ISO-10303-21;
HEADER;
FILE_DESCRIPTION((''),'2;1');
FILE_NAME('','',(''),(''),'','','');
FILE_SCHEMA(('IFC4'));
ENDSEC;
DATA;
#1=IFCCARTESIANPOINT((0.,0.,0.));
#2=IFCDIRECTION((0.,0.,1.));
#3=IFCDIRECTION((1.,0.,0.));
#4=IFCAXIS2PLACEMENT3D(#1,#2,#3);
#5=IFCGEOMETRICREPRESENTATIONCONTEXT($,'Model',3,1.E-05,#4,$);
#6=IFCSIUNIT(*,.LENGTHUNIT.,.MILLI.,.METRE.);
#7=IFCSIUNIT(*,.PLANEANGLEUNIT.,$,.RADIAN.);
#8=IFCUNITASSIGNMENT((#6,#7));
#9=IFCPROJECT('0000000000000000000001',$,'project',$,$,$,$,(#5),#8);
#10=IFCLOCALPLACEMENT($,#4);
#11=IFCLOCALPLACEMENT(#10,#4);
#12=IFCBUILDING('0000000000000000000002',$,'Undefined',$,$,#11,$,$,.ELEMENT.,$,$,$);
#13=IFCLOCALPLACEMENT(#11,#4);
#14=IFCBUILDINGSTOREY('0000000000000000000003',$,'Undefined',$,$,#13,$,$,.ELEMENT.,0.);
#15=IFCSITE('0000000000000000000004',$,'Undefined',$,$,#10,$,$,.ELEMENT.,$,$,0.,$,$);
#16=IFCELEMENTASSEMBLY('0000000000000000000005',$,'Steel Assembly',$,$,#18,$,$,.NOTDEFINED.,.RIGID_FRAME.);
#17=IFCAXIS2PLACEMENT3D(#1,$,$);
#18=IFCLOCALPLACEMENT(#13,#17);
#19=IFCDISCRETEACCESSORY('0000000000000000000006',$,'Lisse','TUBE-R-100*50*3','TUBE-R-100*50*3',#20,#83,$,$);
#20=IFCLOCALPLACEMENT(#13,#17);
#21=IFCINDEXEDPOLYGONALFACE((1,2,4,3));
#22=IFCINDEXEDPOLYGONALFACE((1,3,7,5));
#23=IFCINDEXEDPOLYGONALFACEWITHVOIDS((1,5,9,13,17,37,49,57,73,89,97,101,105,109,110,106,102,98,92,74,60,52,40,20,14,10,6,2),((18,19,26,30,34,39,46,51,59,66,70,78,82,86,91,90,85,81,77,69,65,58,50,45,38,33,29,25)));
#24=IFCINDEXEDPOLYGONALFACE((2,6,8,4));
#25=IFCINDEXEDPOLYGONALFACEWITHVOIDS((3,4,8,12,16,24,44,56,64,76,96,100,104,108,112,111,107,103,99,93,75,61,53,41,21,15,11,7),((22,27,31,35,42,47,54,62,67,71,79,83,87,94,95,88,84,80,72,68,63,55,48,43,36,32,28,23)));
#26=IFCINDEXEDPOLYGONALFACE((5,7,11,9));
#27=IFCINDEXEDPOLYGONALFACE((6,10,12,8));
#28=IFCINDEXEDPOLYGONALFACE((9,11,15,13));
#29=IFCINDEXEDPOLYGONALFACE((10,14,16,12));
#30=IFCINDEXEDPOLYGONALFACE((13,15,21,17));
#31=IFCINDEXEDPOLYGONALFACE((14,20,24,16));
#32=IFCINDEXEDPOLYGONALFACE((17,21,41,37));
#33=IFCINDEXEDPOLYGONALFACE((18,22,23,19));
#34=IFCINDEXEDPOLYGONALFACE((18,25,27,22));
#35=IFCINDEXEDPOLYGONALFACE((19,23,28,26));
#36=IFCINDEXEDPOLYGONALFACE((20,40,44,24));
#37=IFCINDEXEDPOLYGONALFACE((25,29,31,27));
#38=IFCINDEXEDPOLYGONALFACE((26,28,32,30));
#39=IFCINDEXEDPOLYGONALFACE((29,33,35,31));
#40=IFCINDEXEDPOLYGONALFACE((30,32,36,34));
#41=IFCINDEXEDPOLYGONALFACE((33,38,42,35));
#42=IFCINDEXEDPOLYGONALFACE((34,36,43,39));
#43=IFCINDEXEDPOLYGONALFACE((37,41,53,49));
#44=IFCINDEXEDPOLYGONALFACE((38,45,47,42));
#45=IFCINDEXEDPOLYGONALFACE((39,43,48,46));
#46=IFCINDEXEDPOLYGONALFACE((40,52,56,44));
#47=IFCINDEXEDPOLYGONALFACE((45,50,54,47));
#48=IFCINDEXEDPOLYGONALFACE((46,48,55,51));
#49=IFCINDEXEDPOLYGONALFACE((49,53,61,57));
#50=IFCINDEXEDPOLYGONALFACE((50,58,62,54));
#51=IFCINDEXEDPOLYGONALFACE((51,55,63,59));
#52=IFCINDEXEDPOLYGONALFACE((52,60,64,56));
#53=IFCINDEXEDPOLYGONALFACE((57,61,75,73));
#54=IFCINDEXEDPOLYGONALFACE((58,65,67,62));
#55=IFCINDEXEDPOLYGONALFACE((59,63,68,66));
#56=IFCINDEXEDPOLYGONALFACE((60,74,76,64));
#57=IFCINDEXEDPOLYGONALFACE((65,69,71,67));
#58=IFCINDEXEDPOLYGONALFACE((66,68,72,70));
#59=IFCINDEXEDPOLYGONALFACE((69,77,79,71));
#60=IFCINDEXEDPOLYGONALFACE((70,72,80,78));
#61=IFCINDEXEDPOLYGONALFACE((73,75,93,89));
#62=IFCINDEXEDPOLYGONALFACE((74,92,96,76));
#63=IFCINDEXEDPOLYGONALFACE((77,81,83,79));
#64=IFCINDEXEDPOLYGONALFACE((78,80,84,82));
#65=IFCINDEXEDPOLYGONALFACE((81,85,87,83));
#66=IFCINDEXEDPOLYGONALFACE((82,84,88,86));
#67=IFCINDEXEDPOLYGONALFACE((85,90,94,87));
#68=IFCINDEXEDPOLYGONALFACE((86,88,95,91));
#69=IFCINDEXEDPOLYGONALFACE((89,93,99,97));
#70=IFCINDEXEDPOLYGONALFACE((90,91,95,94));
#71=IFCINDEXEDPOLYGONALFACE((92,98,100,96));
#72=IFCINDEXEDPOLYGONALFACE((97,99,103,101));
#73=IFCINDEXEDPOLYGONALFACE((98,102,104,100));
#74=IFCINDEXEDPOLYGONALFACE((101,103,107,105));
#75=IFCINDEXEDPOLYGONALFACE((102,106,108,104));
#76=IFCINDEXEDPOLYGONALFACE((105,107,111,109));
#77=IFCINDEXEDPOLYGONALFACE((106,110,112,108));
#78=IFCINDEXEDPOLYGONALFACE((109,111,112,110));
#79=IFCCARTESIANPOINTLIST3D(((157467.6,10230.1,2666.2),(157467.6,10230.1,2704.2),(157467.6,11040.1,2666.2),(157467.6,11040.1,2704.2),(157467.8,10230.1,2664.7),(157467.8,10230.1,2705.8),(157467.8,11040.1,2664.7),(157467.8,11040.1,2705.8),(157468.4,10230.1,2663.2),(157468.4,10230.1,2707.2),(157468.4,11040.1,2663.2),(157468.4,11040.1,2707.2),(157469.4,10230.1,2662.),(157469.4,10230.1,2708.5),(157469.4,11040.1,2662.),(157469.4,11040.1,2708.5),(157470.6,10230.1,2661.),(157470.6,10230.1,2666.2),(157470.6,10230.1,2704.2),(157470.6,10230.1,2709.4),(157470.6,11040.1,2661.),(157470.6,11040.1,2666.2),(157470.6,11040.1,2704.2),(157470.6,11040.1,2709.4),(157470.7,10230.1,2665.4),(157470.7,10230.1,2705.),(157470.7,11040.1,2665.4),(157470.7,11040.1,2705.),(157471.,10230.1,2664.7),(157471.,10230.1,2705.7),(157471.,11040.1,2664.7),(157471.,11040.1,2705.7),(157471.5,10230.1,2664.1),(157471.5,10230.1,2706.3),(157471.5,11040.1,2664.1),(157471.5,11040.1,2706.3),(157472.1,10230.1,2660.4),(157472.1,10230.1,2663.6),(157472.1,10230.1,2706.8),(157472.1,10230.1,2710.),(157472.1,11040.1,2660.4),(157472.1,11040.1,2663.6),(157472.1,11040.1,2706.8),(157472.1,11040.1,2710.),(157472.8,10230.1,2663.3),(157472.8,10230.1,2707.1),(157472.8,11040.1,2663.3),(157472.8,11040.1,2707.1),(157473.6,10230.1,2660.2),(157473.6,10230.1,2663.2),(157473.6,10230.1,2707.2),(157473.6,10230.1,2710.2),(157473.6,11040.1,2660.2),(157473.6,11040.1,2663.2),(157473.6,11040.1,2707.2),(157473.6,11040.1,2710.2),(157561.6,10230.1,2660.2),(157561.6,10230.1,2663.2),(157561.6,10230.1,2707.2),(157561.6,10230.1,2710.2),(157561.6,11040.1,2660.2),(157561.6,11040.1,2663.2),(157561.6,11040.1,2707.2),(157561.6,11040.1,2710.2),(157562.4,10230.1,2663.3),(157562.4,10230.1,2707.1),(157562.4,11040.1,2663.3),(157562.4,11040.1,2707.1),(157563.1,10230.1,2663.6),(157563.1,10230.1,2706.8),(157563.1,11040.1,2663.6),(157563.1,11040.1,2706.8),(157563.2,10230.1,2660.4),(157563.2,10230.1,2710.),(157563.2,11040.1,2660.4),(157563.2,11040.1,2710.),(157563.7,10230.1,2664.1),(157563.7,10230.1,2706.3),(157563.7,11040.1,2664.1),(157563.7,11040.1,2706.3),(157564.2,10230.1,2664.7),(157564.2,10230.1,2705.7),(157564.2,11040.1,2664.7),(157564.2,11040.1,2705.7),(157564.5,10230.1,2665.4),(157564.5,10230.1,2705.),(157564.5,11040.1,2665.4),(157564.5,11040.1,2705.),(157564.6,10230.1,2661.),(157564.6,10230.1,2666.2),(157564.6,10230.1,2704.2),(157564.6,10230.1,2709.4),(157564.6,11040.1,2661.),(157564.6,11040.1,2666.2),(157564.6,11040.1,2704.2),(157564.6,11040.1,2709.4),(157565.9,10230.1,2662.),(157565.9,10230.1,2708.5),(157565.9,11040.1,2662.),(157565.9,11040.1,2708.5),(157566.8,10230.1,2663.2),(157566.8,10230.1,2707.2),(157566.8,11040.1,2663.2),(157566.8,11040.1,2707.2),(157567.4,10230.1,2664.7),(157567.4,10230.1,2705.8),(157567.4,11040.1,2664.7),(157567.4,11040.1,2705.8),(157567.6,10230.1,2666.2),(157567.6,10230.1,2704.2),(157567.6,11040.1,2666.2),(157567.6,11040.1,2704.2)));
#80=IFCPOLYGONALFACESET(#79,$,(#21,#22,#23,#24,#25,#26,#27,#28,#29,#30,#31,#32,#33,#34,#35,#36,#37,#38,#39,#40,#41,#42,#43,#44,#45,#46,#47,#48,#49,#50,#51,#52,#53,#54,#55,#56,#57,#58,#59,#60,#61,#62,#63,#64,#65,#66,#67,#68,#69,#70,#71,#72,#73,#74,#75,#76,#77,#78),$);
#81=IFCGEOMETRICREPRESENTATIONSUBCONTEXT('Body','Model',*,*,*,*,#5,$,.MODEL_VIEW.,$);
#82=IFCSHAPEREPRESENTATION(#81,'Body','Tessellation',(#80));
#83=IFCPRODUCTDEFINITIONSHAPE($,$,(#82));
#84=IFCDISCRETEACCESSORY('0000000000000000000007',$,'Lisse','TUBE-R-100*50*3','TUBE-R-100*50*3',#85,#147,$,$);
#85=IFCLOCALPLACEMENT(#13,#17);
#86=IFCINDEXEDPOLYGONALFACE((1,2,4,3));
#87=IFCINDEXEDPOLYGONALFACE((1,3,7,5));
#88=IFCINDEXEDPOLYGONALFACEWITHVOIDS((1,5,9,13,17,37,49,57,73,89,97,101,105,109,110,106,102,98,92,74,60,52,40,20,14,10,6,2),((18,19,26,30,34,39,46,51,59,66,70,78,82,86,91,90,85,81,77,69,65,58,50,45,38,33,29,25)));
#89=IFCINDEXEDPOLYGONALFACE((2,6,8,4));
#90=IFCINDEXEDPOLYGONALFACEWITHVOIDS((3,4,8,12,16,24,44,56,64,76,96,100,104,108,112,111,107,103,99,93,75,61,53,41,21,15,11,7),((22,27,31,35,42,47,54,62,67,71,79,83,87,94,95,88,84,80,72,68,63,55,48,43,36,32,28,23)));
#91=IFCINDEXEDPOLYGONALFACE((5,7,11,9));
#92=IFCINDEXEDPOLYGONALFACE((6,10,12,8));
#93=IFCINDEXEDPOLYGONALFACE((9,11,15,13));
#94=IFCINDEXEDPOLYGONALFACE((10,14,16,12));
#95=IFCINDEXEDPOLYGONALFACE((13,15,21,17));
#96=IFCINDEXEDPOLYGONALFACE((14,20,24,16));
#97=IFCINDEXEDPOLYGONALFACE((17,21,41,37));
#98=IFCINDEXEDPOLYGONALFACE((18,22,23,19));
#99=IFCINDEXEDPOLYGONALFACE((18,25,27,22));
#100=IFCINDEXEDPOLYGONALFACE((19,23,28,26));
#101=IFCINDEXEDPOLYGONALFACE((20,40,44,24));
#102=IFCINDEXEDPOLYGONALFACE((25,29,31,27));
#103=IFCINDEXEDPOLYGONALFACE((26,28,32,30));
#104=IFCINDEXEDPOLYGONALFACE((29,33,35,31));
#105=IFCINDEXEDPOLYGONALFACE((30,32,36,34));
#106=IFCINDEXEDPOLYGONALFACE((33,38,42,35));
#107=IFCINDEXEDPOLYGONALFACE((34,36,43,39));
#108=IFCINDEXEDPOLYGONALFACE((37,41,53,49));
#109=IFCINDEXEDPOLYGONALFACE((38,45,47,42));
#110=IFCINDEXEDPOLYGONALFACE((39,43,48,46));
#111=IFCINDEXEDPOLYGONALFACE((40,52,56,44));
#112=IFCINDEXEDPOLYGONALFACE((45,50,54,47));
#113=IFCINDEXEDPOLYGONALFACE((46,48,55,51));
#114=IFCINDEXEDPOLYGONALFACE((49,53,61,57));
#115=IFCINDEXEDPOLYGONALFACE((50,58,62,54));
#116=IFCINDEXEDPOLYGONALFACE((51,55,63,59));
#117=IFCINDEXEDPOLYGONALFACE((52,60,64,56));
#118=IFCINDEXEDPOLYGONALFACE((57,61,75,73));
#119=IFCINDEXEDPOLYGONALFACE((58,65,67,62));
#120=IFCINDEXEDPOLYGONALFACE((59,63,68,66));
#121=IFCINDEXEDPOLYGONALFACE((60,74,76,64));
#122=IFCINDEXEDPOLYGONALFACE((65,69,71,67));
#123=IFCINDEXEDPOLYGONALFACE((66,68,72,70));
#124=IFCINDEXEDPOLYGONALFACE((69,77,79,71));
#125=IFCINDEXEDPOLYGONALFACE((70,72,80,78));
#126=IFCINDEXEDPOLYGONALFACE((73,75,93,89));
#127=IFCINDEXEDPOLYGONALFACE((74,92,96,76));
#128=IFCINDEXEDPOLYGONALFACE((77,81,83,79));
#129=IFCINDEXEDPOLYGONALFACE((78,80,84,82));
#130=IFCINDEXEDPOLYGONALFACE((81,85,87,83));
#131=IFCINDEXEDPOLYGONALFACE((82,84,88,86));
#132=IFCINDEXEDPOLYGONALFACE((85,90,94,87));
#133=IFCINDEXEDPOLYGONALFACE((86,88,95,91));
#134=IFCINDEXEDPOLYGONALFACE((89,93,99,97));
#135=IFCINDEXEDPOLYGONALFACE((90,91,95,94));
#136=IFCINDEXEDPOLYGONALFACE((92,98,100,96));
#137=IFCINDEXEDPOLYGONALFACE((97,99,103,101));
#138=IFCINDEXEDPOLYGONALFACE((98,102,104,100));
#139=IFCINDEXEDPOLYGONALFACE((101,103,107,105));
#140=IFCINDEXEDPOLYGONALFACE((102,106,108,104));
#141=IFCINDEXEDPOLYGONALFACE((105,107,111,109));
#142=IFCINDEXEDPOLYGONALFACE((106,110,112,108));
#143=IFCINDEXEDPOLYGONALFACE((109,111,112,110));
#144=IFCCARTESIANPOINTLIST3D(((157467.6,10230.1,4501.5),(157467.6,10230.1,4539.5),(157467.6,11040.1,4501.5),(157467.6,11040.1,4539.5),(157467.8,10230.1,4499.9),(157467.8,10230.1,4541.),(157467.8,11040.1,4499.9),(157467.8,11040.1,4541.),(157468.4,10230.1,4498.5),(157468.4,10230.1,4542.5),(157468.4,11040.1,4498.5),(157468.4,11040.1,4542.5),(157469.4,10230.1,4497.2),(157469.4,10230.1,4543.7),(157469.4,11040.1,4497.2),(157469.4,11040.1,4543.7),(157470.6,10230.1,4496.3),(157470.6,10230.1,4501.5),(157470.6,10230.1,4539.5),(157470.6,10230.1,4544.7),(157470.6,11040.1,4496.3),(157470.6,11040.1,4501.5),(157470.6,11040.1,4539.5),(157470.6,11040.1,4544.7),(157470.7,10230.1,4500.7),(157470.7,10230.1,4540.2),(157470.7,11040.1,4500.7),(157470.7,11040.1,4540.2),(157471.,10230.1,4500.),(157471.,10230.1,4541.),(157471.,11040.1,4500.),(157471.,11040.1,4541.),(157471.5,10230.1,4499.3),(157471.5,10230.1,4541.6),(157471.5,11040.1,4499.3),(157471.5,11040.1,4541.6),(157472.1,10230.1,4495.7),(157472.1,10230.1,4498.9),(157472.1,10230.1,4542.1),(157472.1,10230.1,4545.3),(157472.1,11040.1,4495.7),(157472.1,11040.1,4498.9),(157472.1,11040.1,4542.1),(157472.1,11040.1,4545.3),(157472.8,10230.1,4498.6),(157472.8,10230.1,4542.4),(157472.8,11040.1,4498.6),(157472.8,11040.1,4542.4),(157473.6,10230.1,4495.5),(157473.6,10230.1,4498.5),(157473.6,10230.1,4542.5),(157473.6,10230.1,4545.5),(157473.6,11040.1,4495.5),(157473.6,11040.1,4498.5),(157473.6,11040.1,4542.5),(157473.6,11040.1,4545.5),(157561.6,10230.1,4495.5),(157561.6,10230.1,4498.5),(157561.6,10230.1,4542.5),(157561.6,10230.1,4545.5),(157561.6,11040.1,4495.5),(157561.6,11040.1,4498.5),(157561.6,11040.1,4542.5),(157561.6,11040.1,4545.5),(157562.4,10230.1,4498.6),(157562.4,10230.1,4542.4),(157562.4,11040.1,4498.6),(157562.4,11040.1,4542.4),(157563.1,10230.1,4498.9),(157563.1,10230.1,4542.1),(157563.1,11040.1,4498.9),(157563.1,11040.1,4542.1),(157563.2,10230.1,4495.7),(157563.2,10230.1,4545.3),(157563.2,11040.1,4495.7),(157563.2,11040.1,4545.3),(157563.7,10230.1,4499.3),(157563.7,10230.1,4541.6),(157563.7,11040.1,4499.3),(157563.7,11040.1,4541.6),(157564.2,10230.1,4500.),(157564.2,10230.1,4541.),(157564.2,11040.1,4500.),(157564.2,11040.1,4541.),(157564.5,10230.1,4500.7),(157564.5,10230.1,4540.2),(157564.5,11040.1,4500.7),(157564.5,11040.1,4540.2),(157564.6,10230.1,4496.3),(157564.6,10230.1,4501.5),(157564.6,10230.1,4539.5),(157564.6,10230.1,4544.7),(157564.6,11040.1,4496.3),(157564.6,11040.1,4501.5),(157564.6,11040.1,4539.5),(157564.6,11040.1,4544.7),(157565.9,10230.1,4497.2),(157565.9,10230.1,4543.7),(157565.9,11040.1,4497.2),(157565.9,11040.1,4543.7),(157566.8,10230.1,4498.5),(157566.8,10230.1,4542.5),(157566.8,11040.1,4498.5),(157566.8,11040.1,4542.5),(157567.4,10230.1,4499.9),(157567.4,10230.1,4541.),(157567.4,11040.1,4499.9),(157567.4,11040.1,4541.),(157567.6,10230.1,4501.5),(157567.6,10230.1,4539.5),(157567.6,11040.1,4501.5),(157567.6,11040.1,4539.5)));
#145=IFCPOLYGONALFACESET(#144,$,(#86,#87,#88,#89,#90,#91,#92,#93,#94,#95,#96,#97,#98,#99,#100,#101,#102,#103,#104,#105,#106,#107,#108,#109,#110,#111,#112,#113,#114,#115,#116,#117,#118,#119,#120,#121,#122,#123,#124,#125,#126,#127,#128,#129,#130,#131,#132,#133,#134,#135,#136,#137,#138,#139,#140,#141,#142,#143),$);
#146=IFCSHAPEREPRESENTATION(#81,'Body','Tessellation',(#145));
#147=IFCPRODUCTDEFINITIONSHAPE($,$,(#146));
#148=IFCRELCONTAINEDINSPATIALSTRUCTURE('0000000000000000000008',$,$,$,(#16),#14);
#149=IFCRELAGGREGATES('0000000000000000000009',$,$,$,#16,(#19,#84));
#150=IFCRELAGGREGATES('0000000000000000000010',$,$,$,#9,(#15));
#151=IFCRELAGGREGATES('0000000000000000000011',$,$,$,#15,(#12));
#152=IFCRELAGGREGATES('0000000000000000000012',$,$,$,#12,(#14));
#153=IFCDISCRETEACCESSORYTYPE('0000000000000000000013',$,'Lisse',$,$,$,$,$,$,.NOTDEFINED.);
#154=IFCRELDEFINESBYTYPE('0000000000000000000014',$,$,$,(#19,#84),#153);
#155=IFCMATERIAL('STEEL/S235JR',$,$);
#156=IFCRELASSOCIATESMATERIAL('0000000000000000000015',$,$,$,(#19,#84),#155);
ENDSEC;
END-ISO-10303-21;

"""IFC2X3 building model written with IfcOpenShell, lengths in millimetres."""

from ifc_helpers import new_model, si_unit, frame, origin_with_axes, origin_2d_with_axis, place, context, subcontext, project, spatial, hollow_rectangle, extrude, material, type_object, element, aggregate, save


model = new_model("IFC2X3")

# Units and contexts
model_context = context("Model", 3, precision=1e-05, world=origin_with_axes())
body_context = subcontext(model_context, "Body", "Model", "MODEL_VIEW")
ifc_project = project(units=[si_unit("LENGTHUNIT", "METRE", prefix="MILLI"), si_unit("PLANEANGLEUNIT", "RADIAN")], contexts=[model_context])

# Site, building, storey
site_placement = place(None, origin_with_axes())
site = spatial("IfcSite", under=ifc_project, at=site_placement, Name="Undefined", CompositionType="ELEMENT", RefElevation=0.0)
building_placement = place(site_placement, origin_with_axes())
building = spatial("IfcBuilding", under=site, at=building_placement, Name="Undefined", CompositionType="ELEMENT")
storey_placement = place(building_placement, origin_with_axes())
storey = spatial("IfcBuildingStorey", under=building, at=storey_placement, Name="Undefined", CompositionType="ELEMENT", Elevation=0.0)

# Shared definitions
ifc_material_1 = material(Name="STEEL/S235JR")

# Element assembly, discrete accessories
discrete_accessory_type_1 = type_object("IfcDiscreteAccessoryType", Name="Lisse")
assembly_1_placement = place(storey_placement, origin_with_axes())
assembly_1 = element("IfcElementAssembly", 1, at=assembly_1_placement, inside=storey, Name="Steel Assembly", AssemblyPlace="NOTDEFINED", PredefinedType="RIGID_FRAME")
discrete_accessory_1_placement = place(assembly_1_placement, frame((157517.6, 10230.1, 2685.2), z_axis=(-1.0, 0.0, 0.0), x_axis=(0.0, 1.0, 0.0)))
discrete_accessory_1 = element("IfcDiscreteAccessory", 2, at=discrete_accessory_1_placement, type_object=discrete_accessory_type_1, material=ifc_material_1, Name="Lisse", Description="TUBE-R-100*50*3", ObjectType="TUBE-R-100*50*3", context=body_context, shape_type="SweptSolid", body=[
    extrude(hollow_rectangle(XDim=50.0, YDim=100.0, WallThickness=3.0, InnerFilletRadius=3.0, OuterFilletRadius=6.0, at=origin_2d_with_axis()), frame((810.0, 0.0, 0.0), z_axis=(-1.0, 0.0, 0.0), x_axis=(0.0, -1.0, 0.0)), (0.0, 0.0, 1.0), 810.0),
])
discrete_accessory_2_placement = place(assembly_1_placement, frame((157517.6, 10230.1, 4520.5), z_axis=(-1.0, 0.0, 0.0), x_axis=(0.0, 1.0, 0.0)))
discrete_accessory_2 = element("IfcDiscreteAccessory", 3, at=discrete_accessory_2_placement, type_object=discrete_accessory_type_1, material=ifc_material_1, Name="Lisse", Description="TUBE-R-100*50*3", ObjectType="TUBE-R-100*50*3", context=body_context, shape_type="SweptSolid", body=[
    extrude(hollow_rectangle(XDim=50.0, YDim=100.0, WallThickness=3.0, InnerFilletRadius=3.0, OuterFilletRadius=6.0, at=origin_2d_with_axis()), frame((810.0, 0.0, 0.0), z_axis=(-1.0, 0.0, 0.0), x_axis=(0.0, -1.0, 0.0)), (0.0, 0.0, 1.0), 810.0),
])
aggregate(assembly_1, [discrete_accessory_1, discrete_accessory_2])

save(model, "model.ifc")
